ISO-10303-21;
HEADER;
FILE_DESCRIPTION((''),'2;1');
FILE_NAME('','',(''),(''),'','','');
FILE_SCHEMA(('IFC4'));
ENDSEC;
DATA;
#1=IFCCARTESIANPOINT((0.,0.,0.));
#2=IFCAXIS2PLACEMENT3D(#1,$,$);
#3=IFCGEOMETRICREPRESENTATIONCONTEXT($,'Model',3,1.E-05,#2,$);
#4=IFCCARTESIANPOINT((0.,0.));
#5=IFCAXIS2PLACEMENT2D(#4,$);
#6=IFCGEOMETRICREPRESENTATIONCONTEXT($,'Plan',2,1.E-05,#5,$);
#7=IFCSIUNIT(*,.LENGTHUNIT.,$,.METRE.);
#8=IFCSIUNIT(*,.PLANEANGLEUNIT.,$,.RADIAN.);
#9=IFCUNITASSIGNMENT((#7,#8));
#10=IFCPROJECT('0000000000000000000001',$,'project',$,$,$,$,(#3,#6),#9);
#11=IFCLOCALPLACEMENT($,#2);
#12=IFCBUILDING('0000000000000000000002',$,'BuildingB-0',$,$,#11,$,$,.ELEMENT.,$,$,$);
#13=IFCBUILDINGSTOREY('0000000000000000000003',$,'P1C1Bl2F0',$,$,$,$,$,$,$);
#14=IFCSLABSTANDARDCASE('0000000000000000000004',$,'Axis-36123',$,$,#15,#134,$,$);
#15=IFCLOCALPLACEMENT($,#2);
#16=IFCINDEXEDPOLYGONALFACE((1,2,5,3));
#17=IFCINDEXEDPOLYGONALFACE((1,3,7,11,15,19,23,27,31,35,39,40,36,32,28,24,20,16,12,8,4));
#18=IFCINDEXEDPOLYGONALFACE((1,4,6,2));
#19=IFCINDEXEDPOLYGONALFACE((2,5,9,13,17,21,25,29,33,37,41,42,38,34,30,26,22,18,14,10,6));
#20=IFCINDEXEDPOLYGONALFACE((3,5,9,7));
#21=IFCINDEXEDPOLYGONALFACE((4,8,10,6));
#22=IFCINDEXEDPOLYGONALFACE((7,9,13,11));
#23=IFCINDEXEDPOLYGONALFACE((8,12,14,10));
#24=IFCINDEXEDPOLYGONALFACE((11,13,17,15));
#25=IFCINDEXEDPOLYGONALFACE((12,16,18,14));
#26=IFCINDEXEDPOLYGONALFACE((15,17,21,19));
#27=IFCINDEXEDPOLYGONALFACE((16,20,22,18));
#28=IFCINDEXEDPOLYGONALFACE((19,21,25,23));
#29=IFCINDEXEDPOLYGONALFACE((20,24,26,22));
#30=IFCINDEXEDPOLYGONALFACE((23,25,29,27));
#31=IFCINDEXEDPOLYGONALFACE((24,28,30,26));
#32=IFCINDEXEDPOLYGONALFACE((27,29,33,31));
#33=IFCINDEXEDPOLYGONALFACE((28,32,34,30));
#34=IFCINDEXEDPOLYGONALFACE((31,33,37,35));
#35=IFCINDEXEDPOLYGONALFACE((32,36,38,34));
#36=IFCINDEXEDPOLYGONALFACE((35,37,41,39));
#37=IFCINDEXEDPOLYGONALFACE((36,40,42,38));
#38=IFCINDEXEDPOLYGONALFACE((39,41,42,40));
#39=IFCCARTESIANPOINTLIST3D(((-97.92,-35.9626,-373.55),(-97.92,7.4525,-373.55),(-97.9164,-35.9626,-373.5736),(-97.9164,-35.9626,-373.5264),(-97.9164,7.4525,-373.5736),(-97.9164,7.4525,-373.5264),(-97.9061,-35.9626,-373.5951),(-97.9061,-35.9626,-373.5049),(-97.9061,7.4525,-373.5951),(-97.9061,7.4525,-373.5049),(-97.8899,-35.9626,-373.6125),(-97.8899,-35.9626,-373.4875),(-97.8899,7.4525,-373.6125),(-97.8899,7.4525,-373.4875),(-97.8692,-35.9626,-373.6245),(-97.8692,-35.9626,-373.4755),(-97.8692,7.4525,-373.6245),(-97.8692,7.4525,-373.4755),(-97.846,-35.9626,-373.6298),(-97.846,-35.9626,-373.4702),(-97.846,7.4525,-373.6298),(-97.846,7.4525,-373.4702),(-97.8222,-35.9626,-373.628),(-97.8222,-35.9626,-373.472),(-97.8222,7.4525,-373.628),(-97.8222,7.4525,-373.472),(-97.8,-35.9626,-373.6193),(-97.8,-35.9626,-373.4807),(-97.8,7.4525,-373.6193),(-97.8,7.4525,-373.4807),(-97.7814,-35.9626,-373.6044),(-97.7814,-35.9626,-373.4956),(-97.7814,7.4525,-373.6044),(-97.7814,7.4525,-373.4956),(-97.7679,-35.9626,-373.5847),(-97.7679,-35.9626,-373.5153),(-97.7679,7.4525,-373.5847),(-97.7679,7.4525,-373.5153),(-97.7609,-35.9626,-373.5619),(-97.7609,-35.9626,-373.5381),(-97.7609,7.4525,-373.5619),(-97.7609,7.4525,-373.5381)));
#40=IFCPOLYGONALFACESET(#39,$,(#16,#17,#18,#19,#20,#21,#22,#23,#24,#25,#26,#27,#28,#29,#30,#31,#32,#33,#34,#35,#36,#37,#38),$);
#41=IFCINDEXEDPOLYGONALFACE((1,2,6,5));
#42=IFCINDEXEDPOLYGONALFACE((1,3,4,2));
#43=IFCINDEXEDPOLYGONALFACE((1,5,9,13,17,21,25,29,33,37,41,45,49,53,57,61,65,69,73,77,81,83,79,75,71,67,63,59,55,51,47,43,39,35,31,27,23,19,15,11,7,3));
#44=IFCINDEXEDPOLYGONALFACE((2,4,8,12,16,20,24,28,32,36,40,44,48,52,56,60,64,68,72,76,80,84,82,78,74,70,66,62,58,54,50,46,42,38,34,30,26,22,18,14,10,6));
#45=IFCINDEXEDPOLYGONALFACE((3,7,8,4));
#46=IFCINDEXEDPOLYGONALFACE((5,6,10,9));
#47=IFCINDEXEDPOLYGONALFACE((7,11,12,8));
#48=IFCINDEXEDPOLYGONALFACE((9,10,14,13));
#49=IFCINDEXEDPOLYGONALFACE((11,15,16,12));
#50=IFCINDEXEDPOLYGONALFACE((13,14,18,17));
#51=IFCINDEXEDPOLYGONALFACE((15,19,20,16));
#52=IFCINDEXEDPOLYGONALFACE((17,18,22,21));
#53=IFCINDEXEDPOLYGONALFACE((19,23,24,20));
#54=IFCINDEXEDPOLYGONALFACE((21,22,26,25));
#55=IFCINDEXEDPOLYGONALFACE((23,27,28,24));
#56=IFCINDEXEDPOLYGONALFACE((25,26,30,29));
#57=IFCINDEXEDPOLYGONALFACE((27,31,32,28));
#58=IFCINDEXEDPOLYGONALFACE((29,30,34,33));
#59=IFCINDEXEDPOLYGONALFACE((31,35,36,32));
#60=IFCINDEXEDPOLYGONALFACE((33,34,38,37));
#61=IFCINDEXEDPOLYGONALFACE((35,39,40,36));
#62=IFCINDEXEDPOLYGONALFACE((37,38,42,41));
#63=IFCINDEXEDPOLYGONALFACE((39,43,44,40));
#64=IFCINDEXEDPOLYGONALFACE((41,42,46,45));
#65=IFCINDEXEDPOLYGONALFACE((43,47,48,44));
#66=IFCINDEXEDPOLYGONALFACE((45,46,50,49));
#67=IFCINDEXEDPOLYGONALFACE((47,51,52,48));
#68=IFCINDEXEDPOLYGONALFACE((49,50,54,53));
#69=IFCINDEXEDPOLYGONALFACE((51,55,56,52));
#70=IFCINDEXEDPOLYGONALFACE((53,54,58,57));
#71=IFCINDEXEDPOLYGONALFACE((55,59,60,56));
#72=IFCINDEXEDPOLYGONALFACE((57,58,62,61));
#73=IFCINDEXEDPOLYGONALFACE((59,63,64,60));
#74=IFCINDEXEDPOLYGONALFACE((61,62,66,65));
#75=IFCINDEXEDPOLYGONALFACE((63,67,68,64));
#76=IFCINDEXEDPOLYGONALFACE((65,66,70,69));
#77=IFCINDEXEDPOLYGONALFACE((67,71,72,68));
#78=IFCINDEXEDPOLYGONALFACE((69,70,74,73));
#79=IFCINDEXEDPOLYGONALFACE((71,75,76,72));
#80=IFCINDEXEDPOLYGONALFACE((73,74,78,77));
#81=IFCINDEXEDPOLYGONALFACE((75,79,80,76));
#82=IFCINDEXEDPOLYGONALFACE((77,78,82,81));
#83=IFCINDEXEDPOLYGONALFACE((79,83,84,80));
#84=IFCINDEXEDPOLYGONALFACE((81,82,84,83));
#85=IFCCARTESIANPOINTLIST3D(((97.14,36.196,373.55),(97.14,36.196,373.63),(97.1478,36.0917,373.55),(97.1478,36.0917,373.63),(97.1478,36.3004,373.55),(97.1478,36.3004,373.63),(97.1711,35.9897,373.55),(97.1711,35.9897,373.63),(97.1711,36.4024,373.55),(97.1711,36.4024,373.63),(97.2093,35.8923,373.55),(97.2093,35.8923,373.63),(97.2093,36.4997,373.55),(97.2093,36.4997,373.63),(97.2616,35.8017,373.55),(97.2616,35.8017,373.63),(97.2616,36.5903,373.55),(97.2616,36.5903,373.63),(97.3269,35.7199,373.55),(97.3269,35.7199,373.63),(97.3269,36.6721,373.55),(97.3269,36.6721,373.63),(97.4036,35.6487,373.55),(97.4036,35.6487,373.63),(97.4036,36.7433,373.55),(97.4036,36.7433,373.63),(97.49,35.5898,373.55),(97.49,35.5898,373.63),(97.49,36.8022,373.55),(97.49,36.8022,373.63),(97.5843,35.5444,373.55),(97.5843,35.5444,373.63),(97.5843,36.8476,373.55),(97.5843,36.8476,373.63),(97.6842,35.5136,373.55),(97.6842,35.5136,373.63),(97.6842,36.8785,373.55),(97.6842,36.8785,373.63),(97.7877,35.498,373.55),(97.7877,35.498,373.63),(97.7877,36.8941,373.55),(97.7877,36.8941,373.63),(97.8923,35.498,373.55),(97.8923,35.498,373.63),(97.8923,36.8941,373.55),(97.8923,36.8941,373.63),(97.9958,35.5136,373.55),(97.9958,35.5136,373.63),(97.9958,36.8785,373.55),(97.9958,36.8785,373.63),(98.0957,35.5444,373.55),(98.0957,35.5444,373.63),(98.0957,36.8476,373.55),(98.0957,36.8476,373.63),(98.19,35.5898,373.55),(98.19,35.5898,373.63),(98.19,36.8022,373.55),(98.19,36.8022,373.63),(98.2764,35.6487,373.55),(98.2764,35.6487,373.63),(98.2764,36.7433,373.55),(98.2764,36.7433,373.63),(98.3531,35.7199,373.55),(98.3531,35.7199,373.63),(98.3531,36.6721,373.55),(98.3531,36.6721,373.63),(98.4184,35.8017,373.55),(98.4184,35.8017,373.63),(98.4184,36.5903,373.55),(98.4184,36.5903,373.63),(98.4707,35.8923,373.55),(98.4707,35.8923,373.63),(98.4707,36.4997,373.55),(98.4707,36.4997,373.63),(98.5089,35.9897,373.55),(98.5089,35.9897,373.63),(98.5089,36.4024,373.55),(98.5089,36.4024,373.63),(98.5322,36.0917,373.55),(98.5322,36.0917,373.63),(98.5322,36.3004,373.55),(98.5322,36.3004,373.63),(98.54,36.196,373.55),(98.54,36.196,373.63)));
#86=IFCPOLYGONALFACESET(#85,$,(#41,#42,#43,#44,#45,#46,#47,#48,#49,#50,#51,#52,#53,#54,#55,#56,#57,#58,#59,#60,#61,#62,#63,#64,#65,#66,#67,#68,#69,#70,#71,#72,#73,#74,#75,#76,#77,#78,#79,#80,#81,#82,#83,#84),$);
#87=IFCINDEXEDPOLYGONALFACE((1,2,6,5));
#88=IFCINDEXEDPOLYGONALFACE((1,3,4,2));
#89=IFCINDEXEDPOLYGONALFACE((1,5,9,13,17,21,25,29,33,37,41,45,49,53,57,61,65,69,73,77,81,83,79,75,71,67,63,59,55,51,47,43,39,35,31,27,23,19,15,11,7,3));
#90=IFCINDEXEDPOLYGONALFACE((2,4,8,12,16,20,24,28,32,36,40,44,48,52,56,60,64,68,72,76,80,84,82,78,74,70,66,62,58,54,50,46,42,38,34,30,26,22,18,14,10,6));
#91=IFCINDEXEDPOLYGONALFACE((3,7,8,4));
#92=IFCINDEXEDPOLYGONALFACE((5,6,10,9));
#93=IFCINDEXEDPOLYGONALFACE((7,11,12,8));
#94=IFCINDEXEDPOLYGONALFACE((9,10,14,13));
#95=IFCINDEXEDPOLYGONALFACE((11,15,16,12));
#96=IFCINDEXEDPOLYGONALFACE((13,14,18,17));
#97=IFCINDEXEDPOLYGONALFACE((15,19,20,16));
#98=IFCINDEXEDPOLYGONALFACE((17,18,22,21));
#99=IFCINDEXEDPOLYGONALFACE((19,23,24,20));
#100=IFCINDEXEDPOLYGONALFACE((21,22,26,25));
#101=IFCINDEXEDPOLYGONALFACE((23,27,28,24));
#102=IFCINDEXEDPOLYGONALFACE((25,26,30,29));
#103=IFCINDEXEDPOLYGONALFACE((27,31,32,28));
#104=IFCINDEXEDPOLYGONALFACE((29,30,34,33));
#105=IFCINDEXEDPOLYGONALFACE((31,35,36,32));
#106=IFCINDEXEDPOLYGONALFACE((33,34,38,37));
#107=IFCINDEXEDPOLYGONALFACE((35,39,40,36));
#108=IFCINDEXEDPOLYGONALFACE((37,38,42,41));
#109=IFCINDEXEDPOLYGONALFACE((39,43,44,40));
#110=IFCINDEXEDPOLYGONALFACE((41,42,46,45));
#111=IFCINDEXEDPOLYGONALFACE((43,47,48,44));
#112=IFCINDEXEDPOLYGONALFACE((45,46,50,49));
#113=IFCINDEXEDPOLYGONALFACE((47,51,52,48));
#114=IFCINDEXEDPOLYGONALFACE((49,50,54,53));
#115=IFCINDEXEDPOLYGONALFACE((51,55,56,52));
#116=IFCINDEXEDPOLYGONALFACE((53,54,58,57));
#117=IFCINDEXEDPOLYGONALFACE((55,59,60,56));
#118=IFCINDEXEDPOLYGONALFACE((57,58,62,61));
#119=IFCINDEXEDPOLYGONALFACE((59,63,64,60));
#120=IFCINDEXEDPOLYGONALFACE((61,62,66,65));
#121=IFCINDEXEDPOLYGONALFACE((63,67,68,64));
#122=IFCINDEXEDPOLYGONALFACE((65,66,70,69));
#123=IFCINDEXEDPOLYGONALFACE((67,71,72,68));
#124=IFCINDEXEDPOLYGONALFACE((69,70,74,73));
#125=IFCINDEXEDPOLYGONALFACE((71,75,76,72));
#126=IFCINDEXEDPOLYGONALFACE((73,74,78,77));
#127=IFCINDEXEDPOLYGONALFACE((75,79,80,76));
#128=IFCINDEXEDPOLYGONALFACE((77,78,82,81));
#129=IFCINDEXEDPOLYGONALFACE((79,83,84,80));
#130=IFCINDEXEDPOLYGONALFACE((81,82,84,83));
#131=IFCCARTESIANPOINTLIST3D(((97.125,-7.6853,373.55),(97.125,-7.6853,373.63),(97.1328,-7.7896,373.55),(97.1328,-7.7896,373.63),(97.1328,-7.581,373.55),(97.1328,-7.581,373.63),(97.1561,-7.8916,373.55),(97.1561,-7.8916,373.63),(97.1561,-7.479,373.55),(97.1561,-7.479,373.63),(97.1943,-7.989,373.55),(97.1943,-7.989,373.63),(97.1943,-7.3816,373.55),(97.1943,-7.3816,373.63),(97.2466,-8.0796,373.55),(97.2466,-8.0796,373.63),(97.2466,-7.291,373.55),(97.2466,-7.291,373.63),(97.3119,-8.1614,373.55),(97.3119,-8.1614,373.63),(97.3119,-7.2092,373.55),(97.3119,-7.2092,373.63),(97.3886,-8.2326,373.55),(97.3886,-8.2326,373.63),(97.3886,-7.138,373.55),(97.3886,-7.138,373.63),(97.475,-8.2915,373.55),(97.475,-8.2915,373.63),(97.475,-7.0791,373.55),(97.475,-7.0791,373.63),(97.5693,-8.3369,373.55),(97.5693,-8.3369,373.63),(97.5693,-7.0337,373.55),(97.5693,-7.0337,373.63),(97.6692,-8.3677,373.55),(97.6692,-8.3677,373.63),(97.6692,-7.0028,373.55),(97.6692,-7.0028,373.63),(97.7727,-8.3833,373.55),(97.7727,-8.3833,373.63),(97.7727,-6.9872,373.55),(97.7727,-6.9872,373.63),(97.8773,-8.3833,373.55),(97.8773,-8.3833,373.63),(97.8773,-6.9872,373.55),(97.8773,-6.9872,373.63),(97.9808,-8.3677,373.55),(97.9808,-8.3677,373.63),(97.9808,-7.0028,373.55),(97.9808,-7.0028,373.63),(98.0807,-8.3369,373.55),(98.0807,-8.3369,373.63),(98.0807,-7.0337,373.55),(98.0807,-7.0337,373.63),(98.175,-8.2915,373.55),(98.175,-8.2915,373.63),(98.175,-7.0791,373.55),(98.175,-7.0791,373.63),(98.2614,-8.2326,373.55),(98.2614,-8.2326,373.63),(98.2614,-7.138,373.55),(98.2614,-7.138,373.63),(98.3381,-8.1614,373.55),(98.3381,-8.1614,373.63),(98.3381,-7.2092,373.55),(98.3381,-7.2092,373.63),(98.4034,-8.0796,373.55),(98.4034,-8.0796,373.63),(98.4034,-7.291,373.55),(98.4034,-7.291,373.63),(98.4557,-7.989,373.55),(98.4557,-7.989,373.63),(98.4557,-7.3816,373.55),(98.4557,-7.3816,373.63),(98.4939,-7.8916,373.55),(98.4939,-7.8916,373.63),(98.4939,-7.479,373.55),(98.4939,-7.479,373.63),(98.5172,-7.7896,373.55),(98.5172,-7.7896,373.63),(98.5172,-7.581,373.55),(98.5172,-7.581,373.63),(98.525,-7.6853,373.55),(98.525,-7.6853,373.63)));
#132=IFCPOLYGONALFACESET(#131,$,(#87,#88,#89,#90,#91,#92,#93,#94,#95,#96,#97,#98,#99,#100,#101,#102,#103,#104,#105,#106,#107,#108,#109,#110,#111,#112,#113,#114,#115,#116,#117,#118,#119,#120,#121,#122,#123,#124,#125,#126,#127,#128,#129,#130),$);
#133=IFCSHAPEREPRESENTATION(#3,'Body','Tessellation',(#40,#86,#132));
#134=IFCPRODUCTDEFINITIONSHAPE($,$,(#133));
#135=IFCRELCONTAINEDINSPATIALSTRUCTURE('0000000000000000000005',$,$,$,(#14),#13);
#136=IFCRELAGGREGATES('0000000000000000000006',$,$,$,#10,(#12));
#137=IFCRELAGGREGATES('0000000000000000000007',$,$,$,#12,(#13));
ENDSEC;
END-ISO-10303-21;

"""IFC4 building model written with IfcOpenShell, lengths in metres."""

from ifc_helpers import new_model, entity, si_unit, frame, origin, origin_2d, place, context, project, spatial, circle, extrude, element, save


model = new_model("IFC4")

# Units and contexts
model_context = context("Model", 3, precision=1e-05, world=origin())
plan_context = context("Plan", 2, precision=1e-05, world=origin_2d())
ifc_project = project(units=[si_unit("LENGTHUNIT", "METRE"), si_unit("PLANEANGLEUNIT", "RADIAN")], contexts=[model_context, plan_context])

# Building, storey
building_placement = place(None, origin())
building = spatial("IfcBuilding", under=ifc_project, at=building_placement, Name="BuildingB-0", CompositionType="ELEMENT")
storey = spatial("IfcBuildingStorey", under=building, Name="P1C1Bl2F0")

# Slab
element("IfcSlabStandardCase", 1, inside=storey, Name="Axis-36123", context=model_context, shape_type="AdvancedSweptSolid", body=[
    entity("IfcSurfaceCurveSweptAreaSolid", entity("IfcCircleProfileDef", "AREA", None, None, 0.08), None, entity("IfcPolyline", [entity("IfcCartesianPoint", [97.84, 35.9626, 373.55]), entity("IfcCartesianPoint", [97.84, -7.4525, 373.55])]), None, None, entity("IfcPlane", entity("IfcAxis2Placement3D", entity("IfcCartesianPoint", [97.84, 35.9626, 373.55]), entity("IfcDirection", [0.0, 0.0, 1.0]), entity("IfcDirection", [1.0, 0.0, 0.0])))),
    extrude(circle(Radius=0.7), frame((97.84, 36.196, 373.55)), (0.0, 0.0, 1.0), 0.08),
    extrude(circle(Radius=0.7), frame((97.825, -7.6853, 373.55)), (0.0, 0.0, 1.0), 0.08),
])

save(model, "model.ifc")
